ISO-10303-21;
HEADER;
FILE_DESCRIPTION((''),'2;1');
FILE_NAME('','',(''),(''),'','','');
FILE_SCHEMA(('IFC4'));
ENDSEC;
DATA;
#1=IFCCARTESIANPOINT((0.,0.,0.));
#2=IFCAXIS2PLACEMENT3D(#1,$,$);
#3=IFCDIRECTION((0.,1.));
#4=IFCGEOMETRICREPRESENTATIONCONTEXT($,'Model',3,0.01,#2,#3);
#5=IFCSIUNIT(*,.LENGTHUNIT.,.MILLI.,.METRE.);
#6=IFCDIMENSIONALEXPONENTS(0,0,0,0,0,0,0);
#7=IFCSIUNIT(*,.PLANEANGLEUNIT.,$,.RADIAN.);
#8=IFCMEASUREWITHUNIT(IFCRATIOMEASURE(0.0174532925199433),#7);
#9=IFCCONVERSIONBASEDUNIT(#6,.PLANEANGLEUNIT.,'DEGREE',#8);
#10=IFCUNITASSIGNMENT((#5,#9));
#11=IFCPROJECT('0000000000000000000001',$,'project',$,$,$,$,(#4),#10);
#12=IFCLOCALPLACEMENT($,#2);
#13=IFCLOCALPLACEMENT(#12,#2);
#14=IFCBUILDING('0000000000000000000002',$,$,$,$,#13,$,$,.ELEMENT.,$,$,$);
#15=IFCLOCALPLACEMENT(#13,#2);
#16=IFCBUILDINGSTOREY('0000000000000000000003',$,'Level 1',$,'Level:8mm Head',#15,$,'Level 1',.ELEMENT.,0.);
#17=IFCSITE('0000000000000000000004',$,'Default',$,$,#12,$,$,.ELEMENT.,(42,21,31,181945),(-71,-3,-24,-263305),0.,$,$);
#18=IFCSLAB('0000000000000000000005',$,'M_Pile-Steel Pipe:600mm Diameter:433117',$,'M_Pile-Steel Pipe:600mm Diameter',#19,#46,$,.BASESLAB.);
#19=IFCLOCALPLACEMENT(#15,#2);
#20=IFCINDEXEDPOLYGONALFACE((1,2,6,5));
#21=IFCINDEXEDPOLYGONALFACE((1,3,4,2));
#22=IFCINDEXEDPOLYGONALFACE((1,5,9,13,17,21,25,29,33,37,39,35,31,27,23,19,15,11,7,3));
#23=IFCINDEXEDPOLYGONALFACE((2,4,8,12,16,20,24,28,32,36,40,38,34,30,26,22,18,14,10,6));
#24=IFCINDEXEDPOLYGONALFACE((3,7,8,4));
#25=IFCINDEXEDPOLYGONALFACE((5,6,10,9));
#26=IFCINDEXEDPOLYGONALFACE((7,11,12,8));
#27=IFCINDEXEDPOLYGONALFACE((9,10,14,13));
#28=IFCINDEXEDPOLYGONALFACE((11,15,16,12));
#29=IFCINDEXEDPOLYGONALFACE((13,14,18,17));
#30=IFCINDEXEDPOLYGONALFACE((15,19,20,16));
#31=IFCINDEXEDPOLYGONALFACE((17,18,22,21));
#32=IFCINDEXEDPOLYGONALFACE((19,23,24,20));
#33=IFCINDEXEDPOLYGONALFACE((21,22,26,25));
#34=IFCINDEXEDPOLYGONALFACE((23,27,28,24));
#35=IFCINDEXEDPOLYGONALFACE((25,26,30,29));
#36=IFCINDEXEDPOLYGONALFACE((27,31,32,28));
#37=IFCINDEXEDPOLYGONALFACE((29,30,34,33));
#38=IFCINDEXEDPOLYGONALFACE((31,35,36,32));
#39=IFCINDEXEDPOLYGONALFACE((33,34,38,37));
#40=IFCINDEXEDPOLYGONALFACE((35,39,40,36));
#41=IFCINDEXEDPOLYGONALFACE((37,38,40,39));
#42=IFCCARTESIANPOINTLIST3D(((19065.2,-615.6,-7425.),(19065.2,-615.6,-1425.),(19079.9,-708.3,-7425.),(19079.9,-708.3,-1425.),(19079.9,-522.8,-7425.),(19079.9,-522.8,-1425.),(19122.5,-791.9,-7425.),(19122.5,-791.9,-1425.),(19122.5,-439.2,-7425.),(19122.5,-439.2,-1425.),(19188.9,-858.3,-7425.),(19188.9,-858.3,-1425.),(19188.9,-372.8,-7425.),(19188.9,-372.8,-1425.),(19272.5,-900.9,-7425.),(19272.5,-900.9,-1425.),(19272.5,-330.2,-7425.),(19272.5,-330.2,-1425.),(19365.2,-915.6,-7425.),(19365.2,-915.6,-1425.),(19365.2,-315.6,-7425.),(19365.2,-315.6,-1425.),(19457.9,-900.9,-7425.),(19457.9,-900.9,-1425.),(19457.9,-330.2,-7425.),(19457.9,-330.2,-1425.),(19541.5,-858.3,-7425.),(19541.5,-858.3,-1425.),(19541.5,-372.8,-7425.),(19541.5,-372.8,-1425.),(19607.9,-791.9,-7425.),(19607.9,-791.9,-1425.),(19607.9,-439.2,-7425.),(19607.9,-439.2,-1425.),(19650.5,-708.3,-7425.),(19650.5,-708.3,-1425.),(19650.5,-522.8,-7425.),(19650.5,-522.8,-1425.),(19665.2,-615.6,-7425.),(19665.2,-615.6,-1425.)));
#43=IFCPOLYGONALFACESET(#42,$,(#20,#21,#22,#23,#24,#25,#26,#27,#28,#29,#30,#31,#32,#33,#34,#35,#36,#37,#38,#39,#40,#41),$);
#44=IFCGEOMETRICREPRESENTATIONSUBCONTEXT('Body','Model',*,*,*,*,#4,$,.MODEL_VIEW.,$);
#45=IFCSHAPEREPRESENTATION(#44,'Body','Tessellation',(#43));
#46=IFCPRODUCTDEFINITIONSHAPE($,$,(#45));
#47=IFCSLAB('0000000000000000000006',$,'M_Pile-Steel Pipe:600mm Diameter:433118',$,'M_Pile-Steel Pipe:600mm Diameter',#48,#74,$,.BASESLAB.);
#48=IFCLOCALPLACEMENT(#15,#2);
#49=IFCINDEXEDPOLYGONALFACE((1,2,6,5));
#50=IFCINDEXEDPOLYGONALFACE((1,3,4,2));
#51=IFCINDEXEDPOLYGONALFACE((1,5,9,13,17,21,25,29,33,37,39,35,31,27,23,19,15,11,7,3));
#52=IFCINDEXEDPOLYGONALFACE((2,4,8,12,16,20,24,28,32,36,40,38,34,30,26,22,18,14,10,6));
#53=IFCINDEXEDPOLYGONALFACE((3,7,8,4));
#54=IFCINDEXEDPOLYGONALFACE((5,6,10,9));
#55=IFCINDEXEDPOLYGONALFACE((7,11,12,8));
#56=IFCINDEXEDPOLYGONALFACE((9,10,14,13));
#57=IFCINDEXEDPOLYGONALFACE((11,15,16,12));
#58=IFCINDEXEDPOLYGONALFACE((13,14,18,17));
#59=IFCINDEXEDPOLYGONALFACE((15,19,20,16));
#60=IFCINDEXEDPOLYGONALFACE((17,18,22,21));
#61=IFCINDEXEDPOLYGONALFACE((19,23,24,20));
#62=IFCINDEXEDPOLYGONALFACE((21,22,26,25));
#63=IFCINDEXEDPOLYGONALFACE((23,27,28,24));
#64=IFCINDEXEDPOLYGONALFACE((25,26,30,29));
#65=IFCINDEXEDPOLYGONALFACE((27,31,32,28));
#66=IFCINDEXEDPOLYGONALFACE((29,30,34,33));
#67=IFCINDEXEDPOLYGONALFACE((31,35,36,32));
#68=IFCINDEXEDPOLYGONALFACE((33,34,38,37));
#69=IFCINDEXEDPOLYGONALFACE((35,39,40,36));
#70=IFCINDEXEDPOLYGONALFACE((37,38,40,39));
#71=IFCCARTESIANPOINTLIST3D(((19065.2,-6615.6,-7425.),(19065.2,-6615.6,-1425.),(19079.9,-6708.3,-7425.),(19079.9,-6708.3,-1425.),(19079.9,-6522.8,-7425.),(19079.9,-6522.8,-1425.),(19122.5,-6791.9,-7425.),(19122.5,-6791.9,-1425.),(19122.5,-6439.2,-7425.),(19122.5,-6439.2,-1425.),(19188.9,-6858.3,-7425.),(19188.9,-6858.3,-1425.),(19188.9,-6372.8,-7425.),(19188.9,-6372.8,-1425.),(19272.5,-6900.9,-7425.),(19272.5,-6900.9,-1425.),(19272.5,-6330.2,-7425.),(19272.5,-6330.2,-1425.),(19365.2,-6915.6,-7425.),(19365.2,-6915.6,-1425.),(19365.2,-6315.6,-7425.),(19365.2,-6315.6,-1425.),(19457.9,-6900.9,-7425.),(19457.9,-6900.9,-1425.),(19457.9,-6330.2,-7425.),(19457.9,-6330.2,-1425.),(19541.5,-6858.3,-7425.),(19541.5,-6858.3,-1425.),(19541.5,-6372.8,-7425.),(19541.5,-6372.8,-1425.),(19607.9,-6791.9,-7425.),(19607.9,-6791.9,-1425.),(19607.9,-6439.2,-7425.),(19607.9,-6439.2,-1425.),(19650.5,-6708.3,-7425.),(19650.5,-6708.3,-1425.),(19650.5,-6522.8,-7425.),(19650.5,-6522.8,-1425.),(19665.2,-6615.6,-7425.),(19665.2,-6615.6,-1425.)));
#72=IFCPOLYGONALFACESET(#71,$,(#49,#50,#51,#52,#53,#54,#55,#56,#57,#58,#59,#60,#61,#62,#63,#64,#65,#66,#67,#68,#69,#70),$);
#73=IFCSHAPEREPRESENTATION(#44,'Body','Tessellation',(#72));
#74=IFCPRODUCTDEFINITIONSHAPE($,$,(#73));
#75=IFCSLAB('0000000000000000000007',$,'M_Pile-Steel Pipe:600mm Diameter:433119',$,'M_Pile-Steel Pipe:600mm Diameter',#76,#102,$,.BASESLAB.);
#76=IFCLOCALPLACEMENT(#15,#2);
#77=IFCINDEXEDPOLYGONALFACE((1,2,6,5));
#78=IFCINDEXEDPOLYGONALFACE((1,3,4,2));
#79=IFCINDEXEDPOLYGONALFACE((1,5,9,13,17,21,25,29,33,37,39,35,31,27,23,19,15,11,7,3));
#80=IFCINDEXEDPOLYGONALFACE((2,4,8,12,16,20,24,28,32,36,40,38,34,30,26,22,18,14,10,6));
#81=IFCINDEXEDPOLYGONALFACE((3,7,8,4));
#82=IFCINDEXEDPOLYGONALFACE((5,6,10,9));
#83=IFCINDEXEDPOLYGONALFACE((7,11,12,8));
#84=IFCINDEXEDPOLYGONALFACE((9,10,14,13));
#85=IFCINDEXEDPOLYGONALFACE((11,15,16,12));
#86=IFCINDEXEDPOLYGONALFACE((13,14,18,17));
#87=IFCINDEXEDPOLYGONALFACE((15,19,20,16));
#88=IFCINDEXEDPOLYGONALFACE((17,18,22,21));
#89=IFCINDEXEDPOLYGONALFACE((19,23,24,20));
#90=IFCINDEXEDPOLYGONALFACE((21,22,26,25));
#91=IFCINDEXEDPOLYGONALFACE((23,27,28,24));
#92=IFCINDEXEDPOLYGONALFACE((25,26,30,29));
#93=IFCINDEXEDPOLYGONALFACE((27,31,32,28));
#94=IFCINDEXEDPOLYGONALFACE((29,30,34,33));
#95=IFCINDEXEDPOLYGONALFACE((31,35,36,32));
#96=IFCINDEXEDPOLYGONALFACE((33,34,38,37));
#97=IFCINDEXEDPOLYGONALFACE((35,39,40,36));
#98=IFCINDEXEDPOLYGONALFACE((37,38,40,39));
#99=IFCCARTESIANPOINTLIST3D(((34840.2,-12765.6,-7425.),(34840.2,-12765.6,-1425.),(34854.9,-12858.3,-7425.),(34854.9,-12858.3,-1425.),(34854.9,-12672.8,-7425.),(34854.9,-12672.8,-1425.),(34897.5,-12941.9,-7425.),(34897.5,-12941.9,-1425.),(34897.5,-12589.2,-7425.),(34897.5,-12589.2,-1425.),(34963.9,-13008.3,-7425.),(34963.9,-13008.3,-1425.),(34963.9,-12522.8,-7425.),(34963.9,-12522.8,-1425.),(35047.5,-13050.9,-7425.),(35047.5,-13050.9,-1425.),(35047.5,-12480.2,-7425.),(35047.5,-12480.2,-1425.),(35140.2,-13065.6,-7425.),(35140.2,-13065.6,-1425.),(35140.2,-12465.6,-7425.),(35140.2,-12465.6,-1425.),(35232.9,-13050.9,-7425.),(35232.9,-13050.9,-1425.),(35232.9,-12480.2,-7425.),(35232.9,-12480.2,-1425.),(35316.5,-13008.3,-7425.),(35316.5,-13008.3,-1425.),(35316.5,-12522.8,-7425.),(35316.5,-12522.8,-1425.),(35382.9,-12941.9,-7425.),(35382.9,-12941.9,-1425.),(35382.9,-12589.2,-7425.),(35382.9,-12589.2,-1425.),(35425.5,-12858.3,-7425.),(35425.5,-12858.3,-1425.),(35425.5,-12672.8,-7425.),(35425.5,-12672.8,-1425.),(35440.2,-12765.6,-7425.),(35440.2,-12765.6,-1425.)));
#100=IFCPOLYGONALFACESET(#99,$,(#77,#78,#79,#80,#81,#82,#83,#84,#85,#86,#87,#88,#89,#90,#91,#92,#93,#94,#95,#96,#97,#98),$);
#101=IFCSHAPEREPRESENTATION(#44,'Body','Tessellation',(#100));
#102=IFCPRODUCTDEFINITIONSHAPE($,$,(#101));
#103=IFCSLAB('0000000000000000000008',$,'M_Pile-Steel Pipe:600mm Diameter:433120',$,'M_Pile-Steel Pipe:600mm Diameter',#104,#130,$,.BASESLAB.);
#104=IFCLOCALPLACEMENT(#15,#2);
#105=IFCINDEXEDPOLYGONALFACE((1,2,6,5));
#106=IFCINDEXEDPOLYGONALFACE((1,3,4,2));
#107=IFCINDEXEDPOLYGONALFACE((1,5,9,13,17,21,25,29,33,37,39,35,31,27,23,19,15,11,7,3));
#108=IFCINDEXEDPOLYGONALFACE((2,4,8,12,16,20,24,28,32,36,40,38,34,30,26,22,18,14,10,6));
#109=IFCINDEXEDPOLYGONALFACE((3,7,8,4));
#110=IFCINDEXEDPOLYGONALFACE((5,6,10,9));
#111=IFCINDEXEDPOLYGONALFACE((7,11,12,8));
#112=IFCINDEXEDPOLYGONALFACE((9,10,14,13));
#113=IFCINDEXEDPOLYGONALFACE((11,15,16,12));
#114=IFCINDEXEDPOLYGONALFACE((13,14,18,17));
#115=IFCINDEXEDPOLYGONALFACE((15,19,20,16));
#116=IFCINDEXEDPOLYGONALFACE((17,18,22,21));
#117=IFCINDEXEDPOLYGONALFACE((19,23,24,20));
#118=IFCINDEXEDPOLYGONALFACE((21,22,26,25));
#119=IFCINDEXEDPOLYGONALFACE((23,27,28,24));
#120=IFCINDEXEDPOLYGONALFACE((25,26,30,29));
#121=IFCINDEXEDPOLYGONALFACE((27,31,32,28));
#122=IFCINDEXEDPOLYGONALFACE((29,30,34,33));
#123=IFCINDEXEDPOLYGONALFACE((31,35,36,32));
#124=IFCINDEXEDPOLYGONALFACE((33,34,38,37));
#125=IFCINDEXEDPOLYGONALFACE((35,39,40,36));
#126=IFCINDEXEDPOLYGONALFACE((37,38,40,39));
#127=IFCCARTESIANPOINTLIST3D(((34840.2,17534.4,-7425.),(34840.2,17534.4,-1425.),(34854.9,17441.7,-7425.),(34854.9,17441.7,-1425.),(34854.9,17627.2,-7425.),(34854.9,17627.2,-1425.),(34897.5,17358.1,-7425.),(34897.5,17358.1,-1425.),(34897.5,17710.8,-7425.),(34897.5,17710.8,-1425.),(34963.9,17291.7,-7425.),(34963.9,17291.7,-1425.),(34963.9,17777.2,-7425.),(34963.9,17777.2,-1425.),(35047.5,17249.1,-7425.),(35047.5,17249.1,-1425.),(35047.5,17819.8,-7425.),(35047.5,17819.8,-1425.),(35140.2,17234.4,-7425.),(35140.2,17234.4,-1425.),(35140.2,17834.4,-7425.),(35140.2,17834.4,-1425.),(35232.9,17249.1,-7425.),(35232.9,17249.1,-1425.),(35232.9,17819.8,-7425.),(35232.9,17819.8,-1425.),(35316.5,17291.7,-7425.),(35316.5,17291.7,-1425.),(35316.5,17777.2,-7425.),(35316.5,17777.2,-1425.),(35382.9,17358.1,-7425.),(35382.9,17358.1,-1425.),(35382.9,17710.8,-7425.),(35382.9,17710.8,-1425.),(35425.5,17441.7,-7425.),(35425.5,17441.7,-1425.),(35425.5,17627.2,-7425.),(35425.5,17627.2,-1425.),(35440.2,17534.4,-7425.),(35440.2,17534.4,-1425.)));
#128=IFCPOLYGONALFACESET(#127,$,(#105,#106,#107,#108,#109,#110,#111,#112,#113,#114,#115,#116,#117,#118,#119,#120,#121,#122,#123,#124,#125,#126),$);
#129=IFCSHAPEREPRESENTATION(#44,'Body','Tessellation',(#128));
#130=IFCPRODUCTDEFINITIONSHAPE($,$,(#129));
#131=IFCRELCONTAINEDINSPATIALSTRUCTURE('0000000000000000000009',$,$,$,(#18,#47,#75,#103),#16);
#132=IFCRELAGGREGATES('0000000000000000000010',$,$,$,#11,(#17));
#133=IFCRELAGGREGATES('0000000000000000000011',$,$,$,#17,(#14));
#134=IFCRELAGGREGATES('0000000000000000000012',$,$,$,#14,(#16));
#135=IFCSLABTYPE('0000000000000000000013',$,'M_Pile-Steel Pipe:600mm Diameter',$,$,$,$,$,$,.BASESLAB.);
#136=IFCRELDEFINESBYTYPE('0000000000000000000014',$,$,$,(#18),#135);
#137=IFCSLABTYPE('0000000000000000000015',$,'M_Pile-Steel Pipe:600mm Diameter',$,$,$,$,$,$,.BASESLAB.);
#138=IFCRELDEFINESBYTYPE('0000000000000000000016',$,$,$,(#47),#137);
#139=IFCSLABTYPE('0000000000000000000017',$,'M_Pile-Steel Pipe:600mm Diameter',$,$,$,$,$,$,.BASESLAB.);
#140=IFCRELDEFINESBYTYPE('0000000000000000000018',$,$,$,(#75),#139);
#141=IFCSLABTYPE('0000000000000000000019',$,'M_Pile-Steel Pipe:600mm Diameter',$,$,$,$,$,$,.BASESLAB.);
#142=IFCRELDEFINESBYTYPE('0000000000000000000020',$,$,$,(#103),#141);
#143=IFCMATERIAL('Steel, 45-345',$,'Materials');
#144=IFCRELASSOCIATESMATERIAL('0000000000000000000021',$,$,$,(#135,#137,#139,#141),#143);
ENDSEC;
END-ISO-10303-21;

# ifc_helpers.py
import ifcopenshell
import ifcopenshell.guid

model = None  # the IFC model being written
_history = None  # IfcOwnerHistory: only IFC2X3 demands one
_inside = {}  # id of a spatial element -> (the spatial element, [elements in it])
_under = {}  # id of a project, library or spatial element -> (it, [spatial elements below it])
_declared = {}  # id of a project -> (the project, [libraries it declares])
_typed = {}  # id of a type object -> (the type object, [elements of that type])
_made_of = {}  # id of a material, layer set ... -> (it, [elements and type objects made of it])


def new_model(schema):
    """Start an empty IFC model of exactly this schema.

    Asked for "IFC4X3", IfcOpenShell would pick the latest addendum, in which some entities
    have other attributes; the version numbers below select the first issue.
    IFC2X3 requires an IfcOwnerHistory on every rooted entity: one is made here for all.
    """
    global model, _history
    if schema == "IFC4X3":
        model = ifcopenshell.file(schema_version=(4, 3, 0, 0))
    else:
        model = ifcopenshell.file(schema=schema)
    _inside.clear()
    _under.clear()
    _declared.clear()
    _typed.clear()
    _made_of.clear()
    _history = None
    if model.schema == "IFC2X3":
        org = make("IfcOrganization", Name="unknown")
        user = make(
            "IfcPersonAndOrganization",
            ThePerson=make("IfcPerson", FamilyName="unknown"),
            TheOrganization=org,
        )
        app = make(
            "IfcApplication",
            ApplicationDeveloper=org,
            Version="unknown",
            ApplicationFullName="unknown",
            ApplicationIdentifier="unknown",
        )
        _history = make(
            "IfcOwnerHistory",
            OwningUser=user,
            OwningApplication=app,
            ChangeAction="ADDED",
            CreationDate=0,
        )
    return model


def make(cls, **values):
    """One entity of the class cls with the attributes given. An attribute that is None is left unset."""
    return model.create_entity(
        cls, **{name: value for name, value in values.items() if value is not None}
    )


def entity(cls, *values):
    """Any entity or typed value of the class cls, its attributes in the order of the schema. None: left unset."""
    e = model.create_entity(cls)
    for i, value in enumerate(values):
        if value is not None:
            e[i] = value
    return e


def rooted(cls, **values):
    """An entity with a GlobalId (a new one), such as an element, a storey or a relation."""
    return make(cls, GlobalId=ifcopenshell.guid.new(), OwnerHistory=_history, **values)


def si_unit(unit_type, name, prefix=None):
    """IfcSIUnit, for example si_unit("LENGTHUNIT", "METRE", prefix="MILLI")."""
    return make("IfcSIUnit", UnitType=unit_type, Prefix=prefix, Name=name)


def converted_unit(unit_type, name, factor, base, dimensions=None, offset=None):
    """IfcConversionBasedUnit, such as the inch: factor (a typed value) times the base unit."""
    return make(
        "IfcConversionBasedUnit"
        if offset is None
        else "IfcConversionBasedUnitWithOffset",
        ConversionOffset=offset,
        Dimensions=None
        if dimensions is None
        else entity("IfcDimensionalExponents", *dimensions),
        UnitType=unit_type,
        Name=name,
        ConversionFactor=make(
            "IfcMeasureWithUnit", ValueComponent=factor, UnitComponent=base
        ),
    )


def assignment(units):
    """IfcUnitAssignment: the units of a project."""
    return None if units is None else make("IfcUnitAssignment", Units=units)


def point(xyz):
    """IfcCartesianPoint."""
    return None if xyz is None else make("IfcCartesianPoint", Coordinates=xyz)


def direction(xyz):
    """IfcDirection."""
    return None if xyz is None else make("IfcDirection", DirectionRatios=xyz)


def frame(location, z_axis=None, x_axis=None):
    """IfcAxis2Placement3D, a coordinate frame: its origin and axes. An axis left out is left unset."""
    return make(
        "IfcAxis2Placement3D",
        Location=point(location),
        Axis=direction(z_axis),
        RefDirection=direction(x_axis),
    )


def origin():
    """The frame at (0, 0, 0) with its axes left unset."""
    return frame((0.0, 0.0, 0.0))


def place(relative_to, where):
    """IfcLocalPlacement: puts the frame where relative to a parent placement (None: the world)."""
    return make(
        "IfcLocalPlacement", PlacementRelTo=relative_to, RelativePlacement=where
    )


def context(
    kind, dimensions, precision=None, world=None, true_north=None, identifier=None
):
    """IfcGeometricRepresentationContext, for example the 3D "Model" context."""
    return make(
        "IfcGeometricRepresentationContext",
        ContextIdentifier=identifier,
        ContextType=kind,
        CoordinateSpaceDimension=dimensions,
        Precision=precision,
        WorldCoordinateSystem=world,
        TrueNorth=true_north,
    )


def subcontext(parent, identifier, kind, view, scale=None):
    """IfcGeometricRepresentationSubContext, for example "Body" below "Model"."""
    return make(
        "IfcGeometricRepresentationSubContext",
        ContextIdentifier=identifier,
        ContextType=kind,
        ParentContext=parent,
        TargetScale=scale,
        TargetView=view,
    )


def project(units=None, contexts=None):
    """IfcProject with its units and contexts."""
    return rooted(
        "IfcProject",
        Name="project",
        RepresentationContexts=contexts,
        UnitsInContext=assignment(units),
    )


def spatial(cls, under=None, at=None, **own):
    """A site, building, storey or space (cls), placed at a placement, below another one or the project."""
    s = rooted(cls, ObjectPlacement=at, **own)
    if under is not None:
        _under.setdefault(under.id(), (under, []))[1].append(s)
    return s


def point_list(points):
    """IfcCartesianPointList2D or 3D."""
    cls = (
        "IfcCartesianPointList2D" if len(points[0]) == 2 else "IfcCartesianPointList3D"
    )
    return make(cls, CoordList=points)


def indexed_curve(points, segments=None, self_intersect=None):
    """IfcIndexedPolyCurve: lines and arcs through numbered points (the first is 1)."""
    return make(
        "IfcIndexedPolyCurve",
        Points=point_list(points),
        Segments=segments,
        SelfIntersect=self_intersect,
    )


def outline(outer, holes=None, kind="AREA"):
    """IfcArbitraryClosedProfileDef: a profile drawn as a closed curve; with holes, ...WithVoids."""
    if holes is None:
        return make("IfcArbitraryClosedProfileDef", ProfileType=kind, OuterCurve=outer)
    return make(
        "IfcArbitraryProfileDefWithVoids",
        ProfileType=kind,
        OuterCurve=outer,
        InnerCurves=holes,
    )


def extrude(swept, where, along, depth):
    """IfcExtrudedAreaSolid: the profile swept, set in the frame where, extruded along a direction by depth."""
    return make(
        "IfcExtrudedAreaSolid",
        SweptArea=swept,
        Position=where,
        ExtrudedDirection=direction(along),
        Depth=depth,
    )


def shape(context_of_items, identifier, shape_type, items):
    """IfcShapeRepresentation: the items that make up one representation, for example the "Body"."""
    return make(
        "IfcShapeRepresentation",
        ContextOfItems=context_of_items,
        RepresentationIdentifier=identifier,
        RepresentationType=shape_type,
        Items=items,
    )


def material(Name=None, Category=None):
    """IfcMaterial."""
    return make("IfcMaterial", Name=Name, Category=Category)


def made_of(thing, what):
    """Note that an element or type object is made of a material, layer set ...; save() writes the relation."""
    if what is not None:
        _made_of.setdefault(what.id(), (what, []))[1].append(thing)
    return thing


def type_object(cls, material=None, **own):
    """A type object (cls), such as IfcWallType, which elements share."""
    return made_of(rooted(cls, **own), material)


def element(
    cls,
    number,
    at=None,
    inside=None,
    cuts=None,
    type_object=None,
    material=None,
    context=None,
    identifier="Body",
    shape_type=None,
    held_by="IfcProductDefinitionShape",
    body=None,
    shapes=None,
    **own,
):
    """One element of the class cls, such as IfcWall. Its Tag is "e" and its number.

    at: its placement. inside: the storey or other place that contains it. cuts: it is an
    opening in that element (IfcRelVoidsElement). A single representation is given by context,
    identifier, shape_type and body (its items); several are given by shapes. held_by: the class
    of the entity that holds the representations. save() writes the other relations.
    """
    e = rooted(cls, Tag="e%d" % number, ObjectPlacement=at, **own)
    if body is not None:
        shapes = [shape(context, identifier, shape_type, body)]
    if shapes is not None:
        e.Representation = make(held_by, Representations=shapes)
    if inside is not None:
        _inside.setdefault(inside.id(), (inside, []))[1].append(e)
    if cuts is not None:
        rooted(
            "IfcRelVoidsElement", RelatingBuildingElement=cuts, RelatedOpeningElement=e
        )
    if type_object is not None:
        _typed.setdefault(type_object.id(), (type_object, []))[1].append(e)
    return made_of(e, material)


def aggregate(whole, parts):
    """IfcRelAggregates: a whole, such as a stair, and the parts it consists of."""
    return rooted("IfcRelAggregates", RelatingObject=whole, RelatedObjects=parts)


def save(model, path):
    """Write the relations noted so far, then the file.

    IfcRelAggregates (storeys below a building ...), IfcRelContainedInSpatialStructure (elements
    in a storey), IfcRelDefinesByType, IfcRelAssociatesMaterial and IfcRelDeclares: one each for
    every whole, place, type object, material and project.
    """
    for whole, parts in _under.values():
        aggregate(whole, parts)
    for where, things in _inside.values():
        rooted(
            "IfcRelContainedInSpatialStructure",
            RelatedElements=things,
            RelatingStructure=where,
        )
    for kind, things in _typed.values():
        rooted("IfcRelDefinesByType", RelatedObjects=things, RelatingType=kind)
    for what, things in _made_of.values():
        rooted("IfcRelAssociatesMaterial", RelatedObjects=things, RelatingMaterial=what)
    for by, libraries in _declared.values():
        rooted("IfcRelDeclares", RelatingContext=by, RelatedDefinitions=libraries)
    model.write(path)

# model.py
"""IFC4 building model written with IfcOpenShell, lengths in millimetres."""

from ifc_helpers import new_model, entity, si_unit, converted_unit, direction, frame, origin, place, context, subcontext, project, spatial, indexed_curve, outline, extrude, material, type_object, element, save


model = new_model("IFC4")

# Units and contexts
model_context = context("Model", 3, precision=0.01, world=origin(), true_north=direction((0.0, 1.0)))
body_context = subcontext(model_context, "Body", "Model", "MODEL_VIEW")
ifc_project = project(units=[si_unit("LENGTHUNIT", "METRE", prefix="MILLI"), converted_unit("PLANEANGLEUNIT", "DEGREE", entity("IfcRatioMeasure", 0.0174532925199433), si_unit("PLANEANGLEUNIT", "RADIAN"), dimensions=[0, 0, 0, 0, 0, 0, 0])], contexts=[model_context])

# Site, building, storey
site_placement = place(None, origin())
site = spatial("IfcSite", under=ifc_project, at=site_placement, Name="Default", CompositionType="ELEMENT", RefLatitude=(42, 21, 31, 181945), RefLongitude=(-71, -3, -24, -263305), RefElevation=0.0)
building_placement = place(site_placement, origin())
building = spatial("IfcBuilding", under=site, at=building_placement, CompositionType="ELEMENT")
storey_placement = place(building_placement, origin())
storey = spatial("IfcBuildingStorey", under=building, at=storey_placement, Name="Level 1", ObjectType="Level:8mm Head", LongName="Level 1", CompositionType="ELEMENT", Elevation=0.0)

# Slabs
ifc_material_1 = material(Name="Steel, 45-345", Category="Materials")
slab_type_1 = type_object("IfcSlabType", Name="M_Pile-Steel Pipe:600mm Diameter", PredefinedType="BASESLAB", material=ifc_material_1)
slab_1_placement = place(building_placement, origin())
element("IfcSlab", 1, at=slab_1_placement, inside=storey, type_object=slab_type_1, Name="M_Pile-Steel Pipe:600mm Diameter:433117", ObjectType="M_Pile-Steel Pipe:600mm Diameter", PredefinedType="BASESLAB", context=body_context, shape_type="SweptSolid", body=[
    extrude(outline(indexed_curve([(300.0, 0.0), (285.3, 92.7), (242.7, 176.3), (176.3, 242.7), (92.7, 285.3), (0.0, 300.0), (-92.7, 285.3), (-176.3, 242.7), (-242.7, 176.3), (-285.3, 92.7), (-300.0, 0.0), (-285.3, -92.7), (-242.7, -176.3), (-176.3, -242.7), (-92.7, -285.3), (0.0, -300.0), (92.7, -285.3), (176.3, -242.7), (242.7, -176.3), (285.3, -92.7), (300.0, 0.0)], self_intersect=False)), frame((19365.2, -615.6, -7425.0)), (0.0, 0.0, 1.0), 6000.0),
])
slab_type_2 = type_object("IfcSlabType", Name="M_Pile-Steel Pipe:600mm Diameter", PredefinedType="BASESLAB", material=ifc_material_1)
slab_2_placement = place(building_placement, origin())
element("IfcSlab", 2, at=slab_2_placement, inside=storey, type_object=slab_type_2, Name="M_Pile-Steel Pipe:600mm Diameter:433118", ObjectType="M_Pile-Steel Pipe:600mm Diameter", PredefinedType="BASESLAB", context=body_context, shape_type="SweptSolid", body=[
    extrude(outline(indexed_curve([(300.0, 0.0), (285.3, 92.7), (242.7, 176.3), (176.3, 242.7), (92.7, 285.3), (0.0, 300.0), (-92.7, 285.3), (-176.3, 242.7), (-242.7, 176.3), (-285.3, 92.7), (-300.0, 0.0), (-285.3, -92.7), (-242.7, -176.3), (-176.3, -242.7), (-92.7, -285.3), (0.0, -300.0), (92.7, -285.3), (176.3, -242.7), (242.7, -176.3), (285.3, -92.7), (300.0, 0.0)], self_intersect=False)), frame((19365.2, -6615.6, -7425.0)), (0.0, 0.0, 1.0), 6000.0),
])
slab_type_3 = type_object("IfcSlabType", Name="M_Pile-Steel Pipe:600mm Diameter", PredefinedType="BASESLAB", material=ifc_material_1)
slab_3_placement = place(building_placement, origin())
element("IfcSlab", 3, at=slab_3_placement, inside=storey, type_object=slab_type_3, Name="M_Pile-Steel Pipe:600mm Diameter:433119", ObjectType="M_Pile-Steel Pipe:600mm Diameter", PredefinedType="BASESLAB", context=body_context, shape_type="SweptSolid", body=[
    extrude(outline(indexed_curve([(300.0, 0.0), (285.3, 92.7), (242.7, 176.3), (176.3, 242.7), (92.7, 285.3), (0.0, 300.0), (-92.7, 285.3), (-176.3, 242.7), (-242.7, 176.3), (-285.3, 92.7), (-300.0, 0.0), (-285.3, -92.7), (-242.7, -176.3), (-176.3, -242.7), (-92.7, -285.3), (0.0, -300.0), (92.7, -285.3), (176.3, -242.7), (242.7, -176.3), (285.3, -92.7), (300.0, 0.0)], self_intersect=False)), frame((35140.2, -12765.6, -7425.0)), (0.0, 0.0, 1.0), 6000.0),
])
slab_type_4 = type_object("IfcSlabType", Name="M_Pile-Steel Pipe:600mm Diameter", PredefinedType="BASESLAB", material=ifc_material_1)
slab_4_placement = place(building_placement, origin())
element("IfcSlab", 4, at=slab_4_placement, inside=storey, type_object=slab_type_4, Name="M_Pile-Steel Pipe:600mm Diameter:433120", ObjectType="M_Pile-Steel Pipe:600mm Diameter", PredefinedType="BASESLAB", context=body_context, shape_type="SweptSolid", body=[
    extrude(outline(indexed_curve([(300.0, 0.0), (285.3, 92.7), (242.7, 176.3), (176.3, 242.7), (92.7, 285.3), (0.0, 300.0), (-92.7, 285.3), (-176.3, 242.7), (-242.7, 176.3), (-285.3, 92.7), (-300.0, 0.0), (-285.3, -92.7), (-242.7, -176.3), (-176.3, -242.7), (-92.7, -285.3), (0.0, -300.0), (92.7, -285.3), (176.3, -242.7), (242.7, -176.3), (285.3, -92.7), (300.0, 0.0)], self_intersect=False)), frame((35140.2, 17534.4, -7425.0)), (0.0, 0.0, 1.0), 6000.0),
])

save(model, "model.ifc")
